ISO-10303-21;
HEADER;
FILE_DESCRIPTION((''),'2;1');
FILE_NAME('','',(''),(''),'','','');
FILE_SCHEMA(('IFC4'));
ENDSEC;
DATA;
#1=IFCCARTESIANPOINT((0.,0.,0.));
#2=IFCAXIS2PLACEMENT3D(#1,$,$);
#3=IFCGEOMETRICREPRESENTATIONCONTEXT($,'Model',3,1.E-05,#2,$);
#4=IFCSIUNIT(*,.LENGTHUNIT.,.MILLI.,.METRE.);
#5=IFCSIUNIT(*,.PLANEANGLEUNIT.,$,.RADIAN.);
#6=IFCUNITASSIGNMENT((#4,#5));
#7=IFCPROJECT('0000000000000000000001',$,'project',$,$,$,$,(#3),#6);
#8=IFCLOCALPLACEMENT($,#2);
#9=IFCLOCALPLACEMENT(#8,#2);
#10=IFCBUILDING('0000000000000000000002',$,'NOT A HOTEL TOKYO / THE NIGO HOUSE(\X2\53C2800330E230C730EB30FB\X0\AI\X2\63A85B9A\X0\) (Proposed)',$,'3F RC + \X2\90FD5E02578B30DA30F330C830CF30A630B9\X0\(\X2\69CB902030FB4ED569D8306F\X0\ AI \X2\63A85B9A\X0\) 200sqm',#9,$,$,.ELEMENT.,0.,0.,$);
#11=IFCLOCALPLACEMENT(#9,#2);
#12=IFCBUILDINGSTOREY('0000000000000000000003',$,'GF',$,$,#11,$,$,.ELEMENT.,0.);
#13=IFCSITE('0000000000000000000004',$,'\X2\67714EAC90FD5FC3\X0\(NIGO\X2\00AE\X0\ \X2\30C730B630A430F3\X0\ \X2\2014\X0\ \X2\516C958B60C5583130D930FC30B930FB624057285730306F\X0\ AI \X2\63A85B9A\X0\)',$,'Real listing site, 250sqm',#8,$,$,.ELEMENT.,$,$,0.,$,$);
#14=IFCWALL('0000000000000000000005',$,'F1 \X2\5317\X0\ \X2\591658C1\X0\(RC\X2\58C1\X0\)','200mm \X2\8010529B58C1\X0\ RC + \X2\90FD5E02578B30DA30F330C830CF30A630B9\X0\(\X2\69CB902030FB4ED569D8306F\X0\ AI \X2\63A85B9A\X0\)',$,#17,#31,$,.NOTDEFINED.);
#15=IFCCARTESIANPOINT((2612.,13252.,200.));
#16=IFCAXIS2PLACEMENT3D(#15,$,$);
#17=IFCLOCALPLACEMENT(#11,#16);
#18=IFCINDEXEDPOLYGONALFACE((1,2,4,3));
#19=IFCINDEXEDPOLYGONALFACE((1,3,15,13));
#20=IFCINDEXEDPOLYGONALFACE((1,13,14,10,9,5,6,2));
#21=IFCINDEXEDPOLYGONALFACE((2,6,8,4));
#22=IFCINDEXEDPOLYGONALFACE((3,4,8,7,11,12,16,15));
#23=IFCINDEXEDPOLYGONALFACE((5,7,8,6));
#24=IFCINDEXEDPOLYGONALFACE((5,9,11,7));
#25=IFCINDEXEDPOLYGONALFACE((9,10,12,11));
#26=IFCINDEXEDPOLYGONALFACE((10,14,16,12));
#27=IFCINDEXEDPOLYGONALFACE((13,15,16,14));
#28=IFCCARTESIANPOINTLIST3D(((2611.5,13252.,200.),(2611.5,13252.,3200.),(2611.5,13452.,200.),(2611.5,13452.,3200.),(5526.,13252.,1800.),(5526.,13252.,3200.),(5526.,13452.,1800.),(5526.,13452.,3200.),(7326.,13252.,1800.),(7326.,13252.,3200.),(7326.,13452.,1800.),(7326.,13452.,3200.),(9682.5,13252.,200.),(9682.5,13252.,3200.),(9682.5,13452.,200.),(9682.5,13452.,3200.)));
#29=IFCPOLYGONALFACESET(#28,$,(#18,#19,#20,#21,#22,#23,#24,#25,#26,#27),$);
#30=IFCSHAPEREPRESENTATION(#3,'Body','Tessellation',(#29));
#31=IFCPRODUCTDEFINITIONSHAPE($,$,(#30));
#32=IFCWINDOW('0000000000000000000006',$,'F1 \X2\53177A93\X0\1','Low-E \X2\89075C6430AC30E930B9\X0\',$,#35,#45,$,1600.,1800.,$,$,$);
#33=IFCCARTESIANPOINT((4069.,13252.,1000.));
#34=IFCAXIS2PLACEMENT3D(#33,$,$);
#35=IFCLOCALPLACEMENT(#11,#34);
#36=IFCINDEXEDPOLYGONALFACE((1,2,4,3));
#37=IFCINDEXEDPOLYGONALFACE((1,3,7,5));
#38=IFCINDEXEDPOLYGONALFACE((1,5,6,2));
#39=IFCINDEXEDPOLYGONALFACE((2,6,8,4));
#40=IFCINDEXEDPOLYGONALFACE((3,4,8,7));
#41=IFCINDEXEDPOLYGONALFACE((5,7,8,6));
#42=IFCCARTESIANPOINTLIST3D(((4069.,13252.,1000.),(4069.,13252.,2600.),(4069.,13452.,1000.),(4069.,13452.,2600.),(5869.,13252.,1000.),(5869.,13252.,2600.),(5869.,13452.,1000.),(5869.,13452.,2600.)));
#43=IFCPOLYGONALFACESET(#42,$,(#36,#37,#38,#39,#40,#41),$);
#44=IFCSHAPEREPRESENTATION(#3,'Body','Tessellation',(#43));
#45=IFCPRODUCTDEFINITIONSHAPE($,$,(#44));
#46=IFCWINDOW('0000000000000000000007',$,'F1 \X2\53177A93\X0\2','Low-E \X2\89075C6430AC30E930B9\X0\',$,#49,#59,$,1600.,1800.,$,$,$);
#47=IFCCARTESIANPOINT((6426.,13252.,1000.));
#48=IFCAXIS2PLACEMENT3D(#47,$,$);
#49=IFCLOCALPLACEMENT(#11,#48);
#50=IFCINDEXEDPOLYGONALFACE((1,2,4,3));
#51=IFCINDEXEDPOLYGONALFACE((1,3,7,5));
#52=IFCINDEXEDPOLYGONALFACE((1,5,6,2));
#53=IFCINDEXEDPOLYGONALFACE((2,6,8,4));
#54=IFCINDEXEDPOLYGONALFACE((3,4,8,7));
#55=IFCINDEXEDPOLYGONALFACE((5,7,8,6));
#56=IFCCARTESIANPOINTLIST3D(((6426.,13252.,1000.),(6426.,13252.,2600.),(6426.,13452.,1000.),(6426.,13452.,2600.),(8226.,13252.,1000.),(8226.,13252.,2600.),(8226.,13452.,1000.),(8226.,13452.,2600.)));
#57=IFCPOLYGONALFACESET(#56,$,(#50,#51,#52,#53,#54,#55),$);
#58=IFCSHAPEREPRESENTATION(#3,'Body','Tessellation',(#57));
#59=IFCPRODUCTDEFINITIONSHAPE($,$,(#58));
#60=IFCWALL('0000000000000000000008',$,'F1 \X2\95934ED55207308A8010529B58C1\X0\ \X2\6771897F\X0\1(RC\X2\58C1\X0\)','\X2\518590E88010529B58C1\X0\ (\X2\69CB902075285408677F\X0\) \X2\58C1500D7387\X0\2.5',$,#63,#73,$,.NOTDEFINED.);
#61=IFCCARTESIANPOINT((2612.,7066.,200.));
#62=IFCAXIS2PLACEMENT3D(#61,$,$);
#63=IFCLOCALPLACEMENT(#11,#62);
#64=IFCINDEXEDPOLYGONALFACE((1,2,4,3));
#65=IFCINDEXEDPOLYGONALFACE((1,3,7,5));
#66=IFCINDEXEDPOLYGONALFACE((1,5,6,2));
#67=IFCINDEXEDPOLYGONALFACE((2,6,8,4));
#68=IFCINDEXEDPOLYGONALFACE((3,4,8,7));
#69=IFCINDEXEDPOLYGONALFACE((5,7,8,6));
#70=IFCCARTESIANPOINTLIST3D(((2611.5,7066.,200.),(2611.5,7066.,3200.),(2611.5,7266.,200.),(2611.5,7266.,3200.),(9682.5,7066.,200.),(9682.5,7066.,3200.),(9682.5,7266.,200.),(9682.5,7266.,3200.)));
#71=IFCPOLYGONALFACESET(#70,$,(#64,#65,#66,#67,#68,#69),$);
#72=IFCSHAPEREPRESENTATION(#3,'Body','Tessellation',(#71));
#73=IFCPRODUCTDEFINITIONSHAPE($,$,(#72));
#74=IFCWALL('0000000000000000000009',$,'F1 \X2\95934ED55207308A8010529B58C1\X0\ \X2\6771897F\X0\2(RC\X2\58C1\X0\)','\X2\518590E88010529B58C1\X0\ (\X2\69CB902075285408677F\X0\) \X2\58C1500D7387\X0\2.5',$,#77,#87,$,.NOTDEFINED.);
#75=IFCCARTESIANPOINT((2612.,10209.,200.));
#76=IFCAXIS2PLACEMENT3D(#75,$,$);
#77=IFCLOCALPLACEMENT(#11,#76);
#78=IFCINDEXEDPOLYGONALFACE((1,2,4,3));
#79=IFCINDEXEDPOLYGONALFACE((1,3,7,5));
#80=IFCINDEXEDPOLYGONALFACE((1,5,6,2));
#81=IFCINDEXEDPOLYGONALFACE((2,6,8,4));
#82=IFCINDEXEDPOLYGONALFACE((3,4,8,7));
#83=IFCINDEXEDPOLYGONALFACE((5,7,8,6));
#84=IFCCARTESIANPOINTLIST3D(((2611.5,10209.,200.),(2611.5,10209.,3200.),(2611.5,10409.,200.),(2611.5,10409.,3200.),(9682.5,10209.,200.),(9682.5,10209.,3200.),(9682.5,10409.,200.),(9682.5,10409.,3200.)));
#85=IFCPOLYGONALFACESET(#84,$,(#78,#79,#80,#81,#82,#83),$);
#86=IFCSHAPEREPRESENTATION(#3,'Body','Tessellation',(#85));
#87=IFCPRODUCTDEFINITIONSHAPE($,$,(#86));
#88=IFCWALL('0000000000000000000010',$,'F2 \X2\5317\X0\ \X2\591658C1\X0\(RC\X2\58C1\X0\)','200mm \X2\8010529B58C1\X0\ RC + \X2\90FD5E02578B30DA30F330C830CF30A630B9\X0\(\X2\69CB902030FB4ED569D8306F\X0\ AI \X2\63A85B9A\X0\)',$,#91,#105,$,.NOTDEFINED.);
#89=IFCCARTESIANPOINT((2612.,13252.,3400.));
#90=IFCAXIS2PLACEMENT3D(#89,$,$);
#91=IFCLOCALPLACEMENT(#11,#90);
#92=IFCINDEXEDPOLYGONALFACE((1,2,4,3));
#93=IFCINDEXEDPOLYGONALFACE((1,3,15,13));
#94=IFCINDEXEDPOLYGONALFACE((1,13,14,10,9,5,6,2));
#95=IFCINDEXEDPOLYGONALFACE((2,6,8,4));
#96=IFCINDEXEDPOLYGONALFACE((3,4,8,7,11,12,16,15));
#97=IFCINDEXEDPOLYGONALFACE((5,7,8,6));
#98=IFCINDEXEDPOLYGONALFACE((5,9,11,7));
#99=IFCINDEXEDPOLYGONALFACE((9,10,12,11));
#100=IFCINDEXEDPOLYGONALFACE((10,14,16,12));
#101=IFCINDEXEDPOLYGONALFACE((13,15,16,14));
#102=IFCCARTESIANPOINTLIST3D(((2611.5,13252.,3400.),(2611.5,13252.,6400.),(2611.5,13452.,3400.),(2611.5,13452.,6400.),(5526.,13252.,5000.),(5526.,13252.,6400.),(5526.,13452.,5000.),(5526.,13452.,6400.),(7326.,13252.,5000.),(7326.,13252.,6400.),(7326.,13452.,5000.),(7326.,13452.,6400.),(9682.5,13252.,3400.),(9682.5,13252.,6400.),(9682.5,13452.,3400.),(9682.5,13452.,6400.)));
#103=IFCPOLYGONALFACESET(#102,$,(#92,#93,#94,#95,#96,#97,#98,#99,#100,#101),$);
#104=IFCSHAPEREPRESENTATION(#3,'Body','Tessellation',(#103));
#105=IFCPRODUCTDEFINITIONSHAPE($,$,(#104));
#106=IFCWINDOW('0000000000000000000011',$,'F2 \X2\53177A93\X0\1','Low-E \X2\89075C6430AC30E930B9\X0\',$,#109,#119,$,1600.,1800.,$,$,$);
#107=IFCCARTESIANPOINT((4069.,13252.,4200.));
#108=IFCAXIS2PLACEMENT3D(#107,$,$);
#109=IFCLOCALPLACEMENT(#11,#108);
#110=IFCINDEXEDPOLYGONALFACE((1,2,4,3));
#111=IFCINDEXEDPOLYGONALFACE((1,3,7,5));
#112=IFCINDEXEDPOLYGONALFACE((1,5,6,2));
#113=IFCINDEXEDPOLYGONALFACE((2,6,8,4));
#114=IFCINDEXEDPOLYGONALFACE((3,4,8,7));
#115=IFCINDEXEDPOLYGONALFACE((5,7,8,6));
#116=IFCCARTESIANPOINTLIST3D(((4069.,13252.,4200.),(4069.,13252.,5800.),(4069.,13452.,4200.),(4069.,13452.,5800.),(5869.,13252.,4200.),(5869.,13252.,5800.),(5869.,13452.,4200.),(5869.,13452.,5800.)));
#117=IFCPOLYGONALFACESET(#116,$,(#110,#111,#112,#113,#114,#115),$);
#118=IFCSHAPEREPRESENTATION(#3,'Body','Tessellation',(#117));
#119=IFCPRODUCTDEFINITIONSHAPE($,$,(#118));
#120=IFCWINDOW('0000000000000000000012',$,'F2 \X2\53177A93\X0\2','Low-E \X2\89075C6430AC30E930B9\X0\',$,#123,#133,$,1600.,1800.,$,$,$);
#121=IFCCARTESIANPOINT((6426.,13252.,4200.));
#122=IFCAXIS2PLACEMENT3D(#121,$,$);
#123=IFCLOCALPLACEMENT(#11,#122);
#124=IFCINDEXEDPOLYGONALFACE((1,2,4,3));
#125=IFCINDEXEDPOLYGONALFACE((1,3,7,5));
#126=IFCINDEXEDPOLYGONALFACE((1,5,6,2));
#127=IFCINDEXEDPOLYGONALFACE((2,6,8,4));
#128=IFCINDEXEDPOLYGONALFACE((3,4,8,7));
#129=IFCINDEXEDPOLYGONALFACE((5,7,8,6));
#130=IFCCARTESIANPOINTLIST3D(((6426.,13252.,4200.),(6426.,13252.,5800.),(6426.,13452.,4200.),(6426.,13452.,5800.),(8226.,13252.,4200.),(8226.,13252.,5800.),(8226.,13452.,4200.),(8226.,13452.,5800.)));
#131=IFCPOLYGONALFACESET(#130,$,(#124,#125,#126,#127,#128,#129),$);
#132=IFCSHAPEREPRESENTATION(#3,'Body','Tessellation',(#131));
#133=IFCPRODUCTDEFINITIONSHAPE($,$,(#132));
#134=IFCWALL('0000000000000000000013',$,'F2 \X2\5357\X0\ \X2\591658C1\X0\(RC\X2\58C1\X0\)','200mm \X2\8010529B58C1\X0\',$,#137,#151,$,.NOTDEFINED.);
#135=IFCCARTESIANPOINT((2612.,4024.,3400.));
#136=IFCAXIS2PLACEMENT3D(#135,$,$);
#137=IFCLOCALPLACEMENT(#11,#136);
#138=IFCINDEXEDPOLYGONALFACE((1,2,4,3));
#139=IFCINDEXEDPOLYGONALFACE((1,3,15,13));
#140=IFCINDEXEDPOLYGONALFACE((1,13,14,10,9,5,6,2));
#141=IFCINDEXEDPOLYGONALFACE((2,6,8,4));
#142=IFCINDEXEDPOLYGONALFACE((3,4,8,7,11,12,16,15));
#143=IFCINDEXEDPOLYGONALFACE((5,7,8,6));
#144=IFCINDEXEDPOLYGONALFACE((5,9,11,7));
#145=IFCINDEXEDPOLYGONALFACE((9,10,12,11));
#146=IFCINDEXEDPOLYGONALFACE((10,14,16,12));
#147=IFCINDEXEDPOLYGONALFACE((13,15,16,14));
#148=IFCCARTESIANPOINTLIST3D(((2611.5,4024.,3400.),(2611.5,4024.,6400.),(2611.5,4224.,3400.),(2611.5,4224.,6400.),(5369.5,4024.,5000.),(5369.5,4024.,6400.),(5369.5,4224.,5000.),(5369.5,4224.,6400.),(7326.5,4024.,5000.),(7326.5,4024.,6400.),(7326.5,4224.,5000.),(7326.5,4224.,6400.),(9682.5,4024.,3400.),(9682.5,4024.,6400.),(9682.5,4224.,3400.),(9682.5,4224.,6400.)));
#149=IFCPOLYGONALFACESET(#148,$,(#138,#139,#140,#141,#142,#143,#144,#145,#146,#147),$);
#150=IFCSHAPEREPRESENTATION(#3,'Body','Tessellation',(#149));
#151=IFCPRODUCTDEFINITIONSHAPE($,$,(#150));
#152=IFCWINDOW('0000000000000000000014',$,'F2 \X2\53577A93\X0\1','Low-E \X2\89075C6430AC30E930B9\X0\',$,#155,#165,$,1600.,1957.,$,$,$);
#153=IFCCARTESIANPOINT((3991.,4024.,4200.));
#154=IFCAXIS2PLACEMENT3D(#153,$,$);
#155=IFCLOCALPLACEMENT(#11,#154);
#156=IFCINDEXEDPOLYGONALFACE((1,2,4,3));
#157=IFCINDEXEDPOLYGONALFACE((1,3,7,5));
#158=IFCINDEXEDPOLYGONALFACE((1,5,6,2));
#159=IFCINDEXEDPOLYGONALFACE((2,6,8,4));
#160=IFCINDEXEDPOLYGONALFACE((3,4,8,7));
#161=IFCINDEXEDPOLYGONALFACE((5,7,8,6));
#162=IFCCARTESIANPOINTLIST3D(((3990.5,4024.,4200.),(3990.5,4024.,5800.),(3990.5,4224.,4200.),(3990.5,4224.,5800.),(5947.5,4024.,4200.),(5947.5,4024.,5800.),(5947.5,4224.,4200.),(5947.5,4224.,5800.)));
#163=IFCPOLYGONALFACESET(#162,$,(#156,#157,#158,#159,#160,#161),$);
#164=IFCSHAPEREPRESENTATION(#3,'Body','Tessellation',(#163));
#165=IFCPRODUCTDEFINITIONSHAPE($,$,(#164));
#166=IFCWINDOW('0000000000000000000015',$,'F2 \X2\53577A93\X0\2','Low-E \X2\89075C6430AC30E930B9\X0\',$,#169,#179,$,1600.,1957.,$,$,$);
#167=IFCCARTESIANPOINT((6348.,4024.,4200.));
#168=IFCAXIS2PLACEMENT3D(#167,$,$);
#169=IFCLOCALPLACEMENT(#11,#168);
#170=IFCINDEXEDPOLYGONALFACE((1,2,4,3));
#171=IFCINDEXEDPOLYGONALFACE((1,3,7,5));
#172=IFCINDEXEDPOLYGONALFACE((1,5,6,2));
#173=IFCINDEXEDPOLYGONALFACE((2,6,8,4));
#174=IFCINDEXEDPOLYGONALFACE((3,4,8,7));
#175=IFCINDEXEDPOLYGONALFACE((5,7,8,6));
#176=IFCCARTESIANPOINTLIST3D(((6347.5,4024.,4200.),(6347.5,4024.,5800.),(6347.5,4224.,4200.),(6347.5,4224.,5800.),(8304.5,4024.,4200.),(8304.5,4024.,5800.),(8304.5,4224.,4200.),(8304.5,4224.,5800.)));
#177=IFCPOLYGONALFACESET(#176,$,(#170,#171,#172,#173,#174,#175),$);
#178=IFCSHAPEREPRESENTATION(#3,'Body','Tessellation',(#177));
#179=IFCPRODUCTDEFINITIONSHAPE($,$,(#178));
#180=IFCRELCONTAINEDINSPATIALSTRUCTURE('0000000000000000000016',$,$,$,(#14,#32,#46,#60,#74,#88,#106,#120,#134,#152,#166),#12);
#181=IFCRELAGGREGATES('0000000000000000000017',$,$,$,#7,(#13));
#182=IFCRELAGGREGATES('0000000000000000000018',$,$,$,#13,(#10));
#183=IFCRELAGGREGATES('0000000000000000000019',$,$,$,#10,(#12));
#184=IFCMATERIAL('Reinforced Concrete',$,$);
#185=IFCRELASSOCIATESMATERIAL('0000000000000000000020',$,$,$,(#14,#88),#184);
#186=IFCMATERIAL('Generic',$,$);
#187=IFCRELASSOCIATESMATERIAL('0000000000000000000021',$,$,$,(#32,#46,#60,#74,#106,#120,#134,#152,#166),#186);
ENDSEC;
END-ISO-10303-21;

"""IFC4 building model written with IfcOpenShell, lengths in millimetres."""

from ifc_helpers import new_model, si_unit, frame, frame_2d, origin, place, context, project, spatial, rectangle, extrude, material, element, fill, save


model = new_model("IFC4")

# Units and contexts
model_context = context("Model", 3, precision=1e-05, world=origin())
ifc_project = project(units=[si_unit("LENGTHUNIT", "METRE", prefix="MILLI"), si_unit("PLANEANGLEUNIT", "RADIAN")], contexts=[model_context])

# Site, building, storey
site_placement = place(None, origin())
site = spatial("IfcSite", under=ifc_project, at=site_placement, Name="東京都心(NIGO® デザイン — 公開情報ベース・所在地は AI 推定)", ObjectType="Real listing site, 250sqm", CompositionType="ELEMENT", RefElevation=0.0)
building_placement = place(site_placement, origin())
building = spatial("IfcBuilding", under=site, at=building_placement, Name="NOT A HOTEL TOKYO / THE NIGO HOUSE(参考モデル・AI推定) (Proposed)", ObjectType="3F RC + 都市型ペントハウス(構造・仕様は AI 推定) 200sqm", CompositionType="ELEMENT", ElevationOfRefHeight=0.0, ElevationOfTerrain=0.0)
storey_placement = place(building_placement, origin())
storey = spatial("IfcBuildingStorey", under=building, at=storey_placement, Name="GF", CompositionType="ELEMENT", Elevation=0.0)

# Wall, openings, windows
ifc_material_1 = material(Name="Reinforced Concrete")
wall_1_placement = place(storey_placement, frame((2612.0, 13252.0, 200.0)))
wall_1 = element("IfcWall", 1, at=wall_1_placement, inside=storey, material=ifc_material_1, Name="F1 北 外壁(RC壁)", Description="200mm 耐力壁 RC + 都市型ペントハウス(構造・仕様は AI 推定)", PredefinedType="NOTDEFINED", context=model_context, shape_type="SweptSolid", body=[
    extrude(rectangle(XDim=7071.0, YDim=200.0, at=frame_2d((3535.0, 100.0))), frame((2612.0, 13252.0, 200.0)), (0.0, 0.0, 1.0), 3000.0),
])
opening_1_placement = place(storey_placement, frame((4069.0, 13252.0, 1000.0)))
opening_1 = element("IfcOpeningElement", 2, at=opening_1_placement, cuts=wall_1, PredefinedType="NOTDEFINED", context=model_context, shape_type="SweptSolid", body=[
    extrude(rectangle(XDim=1800.0, YDim=200.0, at=frame_2d((900.0, 100.0))), frame((4069.0, 13252.0, 1000.0)), (0.0, 0.0, 1.0), 1600.0),
])
opening_2_placement = place(storey_placement, frame((6426.0, 13252.0, 1000.0)))
opening_2 = element("IfcOpeningElement", 3, at=opening_2_placement, cuts=wall_1, PredefinedType="NOTDEFINED", context=model_context, shape_type="SweptSolid", body=[
    extrude(rectangle(XDim=1800.0, YDim=200.0, at=frame_2d((900.0, 100.0))), frame((6426.0, 13252.0, 1000.0)), (0.0, 0.0, 1.0), 1600.0),
])
ifc_material_2 = material(Name="Generic")
window_1_placement = place(storey_placement, frame((4069.0, 13252.0, 1000.0)))
window_1 = element("IfcWindow", 4, at=window_1_placement, inside=storey, material=ifc_material_2, Name="F1 北窓1", Description="Low-E 複層ガラス", OverallHeight=1600.0, OverallWidth=1800.0, context=model_context, shape_type="SweptSolid", body=[
    extrude(rectangle(XDim=1800.0, YDim=200.0, at=frame_2d((900.0, 100.0))), frame((4069.0, 13252.0, 1000.0)), (0.0, 0.0, 1.0), 1600.0),
])
fill(opening_1, window_1)
window_2_placement = place(storey_placement, frame((6426.0, 13252.0, 1000.0)))
window_2 = element("IfcWindow", 5, at=window_2_placement, inside=storey, material=ifc_material_2, Name="F1 北窓2", Description="Low-E 複層ガラス", OverallHeight=1600.0, OverallWidth=1800.0, context=model_context, shape_type="SweptSolid", body=[
    extrude(rectangle(XDim=1800.0, YDim=200.0, at=frame_2d((900.0, 100.0))), frame((6426.0, 13252.0, 1000.0)), (0.0, 0.0, 1.0), 1600.0),
])
fill(opening_2, window_2)

# Walls
wall_2_placement = place(storey_placement, frame((2612.0, 7066.0, 200.0)))
element("IfcWall", 6, at=wall_2_placement, inside=storey, material=ifc_material_2, Name="F1 間仕切り耐力壁 東西1(RC壁)", Description="内部耐力壁 (構造用合板) 壁倍率2.5", PredefinedType="NOTDEFINED", context=model_context, shape_type="SweptSolid", body=[
    extrude(rectangle(XDim=7071.0, YDim=200.0, at=frame_2d((3535.0, 100.0))), frame((2612.0, 7066.0, 200.0)), (0.0, 0.0, 1.0), 3000.0),
])
wall_3_placement = place(storey_placement, frame((2612.0, 10209.0, 200.0)))
element("IfcWall", 7, at=wall_3_placement, inside=storey, material=ifc_material_2, Name="F1 間仕切り耐力壁 東西2(RC壁)", Description="内部耐力壁 (構造用合板) 壁倍率2.5", PredefinedType="NOTDEFINED", context=model_context, shape_type="SweptSolid", body=[
    extrude(rectangle(XDim=7071.0, YDim=200.0, at=frame_2d((3535.0, 100.0))), frame((2612.0, 10209.0, 200.0)), (0.0, 0.0, 1.0), 3000.0),
])

# Walls, openings, windows
wall_4_placement = place(storey_placement, frame((2612.0, 13252.0, 3400.0)))
wall_4 = element("IfcWall", 8, at=wall_4_placement, inside=storey, material=ifc_material_1, Name="F2 北 外壁(RC壁)", Description="200mm 耐力壁 RC + 都市型ペントハウス(構造・仕様は AI 推定)", PredefinedType="NOTDEFINED", context=model_context, shape_type="SweptSolid", body=[
    extrude(rectangle(XDim=7071.0, YDim=200.0, at=frame_2d((3535.0, 100.0))), frame((2612.0, 13252.0, 3400.0)), (0.0, 0.0, 1.0), 3000.0),
])
opening_3_placement = place(storey_placement, frame((4069.0, 13252.0, 4200.0)))
opening_3 = element("IfcOpeningElement", 9, at=opening_3_placement, cuts=wall_4, PredefinedType="NOTDEFINED", context=model_context, shape_type="SweptSolid", body=[
    extrude(rectangle(XDim=1800.0, YDim=200.0, at=frame_2d((900.0, 100.0))), frame((4069.0, 13252.0, 4200.0)), (0.0, 0.0, 1.0), 1600.0),
])
opening_4_placement = place(storey_placement, frame((6426.0, 13252.0, 4200.0)))
opening_4 = element("IfcOpeningElement", 10, at=opening_4_placement, cuts=wall_4, PredefinedType="NOTDEFINED", context=model_context, shape_type="SweptSolid", body=[
    extrude(rectangle(XDim=1800.0, YDim=200.0, at=frame_2d((900.0, 100.0))), frame((6426.0, 13252.0, 4200.0)), (0.0, 0.0, 1.0), 1600.0),
])
window_3_placement = place(storey_placement, frame((4069.0, 13252.0, 4200.0)))
window_3 = element("IfcWindow", 11, at=window_3_placement, inside=storey, material=ifc_material_2, Name="F2 北窓1", Description="Low-E 複層ガラス", OverallHeight=1600.0, OverallWidth=1800.0, context=model_context, shape_type="SweptSolid", body=[
    extrude(rectangle(XDim=1800.0, YDim=200.0, at=frame_2d((900.0, 100.0))), frame((4069.0, 13252.0, 4200.0)), (0.0, 0.0, 1.0), 1600.0),
])
fill(opening_3, window_3)
window_4_placement = place(storey_placement, frame((6426.0, 13252.0, 4200.0)))
window_4 = element("IfcWindow", 12, at=window_4_placement, inside=storey, material=ifc_material_2, Name="F2 北窓2", Description="Low-E 複層ガラス", OverallHeight=1600.0, OverallWidth=1800.0, context=model_context, shape_type="SweptSolid", body=[
    extrude(rectangle(XDim=1800.0, YDim=200.0, at=frame_2d((900.0, 100.0))), frame((6426.0, 13252.0, 4200.0)), (0.0, 0.0, 1.0), 1600.0),
])
fill(opening_4, window_4)
wall_5_placement = place(storey_placement, frame((2612.0, 4024.0, 3400.0)))
wall_5 = element("IfcWall", 13, at=wall_5_placement, inside=storey, material=ifc_material_2, Name="F2 南 外壁(RC壁)", Description="200mm 耐力壁", PredefinedType="NOTDEFINED", context=model_context, shape_type="SweptSolid", body=[
    extrude(rectangle(XDim=7071.0, YDim=200.0, at=frame_2d((3535.0, 100.0))), frame((2612.0, 4024.0, 3400.0)), (0.0, 0.0, 1.0), 3000.0),
])
opening_5_placement = place(storey_placement, frame((3991.0, 4024.0, 4200.0)))
opening_5 = element("IfcOpeningElement", 14, at=opening_5_placement, cuts=wall_5, PredefinedType="NOTDEFINED", context=model_context, shape_type="SweptSolid", body=[
    extrude(rectangle(XDim=1957.0, YDim=200.0, at=frame_2d((978.0, 100.0))), frame((3991.0, 4024.0, 4200.0)), (0.0, 0.0, 1.0), 1600.0),
])
opening_6_placement = place(storey_placement, frame((6348.0, 4024.0, 4200.0)))
opening_6 = element("IfcOpeningElement", 15, at=opening_6_placement, cuts=wall_5, PredefinedType="NOTDEFINED", context=model_context, shape_type="SweptSolid", body=[
    extrude(rectangle(XDim=1957.0, YDim=200.0, at=frame_2d((978.0, 100.0))), frame((6348.0, 4024.0, 4200.0)), (0.0, 0.0, 1.0), 1600.0),
])
window_5_placement = place(storey_placement, frame((3991.0, 4024.0, 4200.0)))
window_5 = element("IfcWindow", 16, at=window_5_placement, inside=storey, material=ifc_material_2, Name="F2 南窓1", Description="Low-E 複層ガラス", OverallHeight=1600.0, OverallWidth=1957.0, context=model_context, shape_type="SweptSolid", body=[
    extrude(rectangle(XDim=1957.0, YDim=200.0, at=frame_2d((978.0, 100.0))), frame((3991.0, 4024.0, 4200.0)), (0.0, 0.0, 1.0), 1600.0),
])
fill(opening_5, window_5)
window_6_placement = place(storey_placement, frame((6348.0, 4024.0, 4200.0)))
window_6 = element("IfcWindow", 17, at=window_6_placement, inside=storey, material=ifc_material_2, Name="F2 南窓2", Description="Low-E 複層ガラス", OverallHeight=1600.0, OverallWidth=1957.0, context=model_context, shape_type="SweptSolid", body=[
    extrude(rectangle(XDim=1957.0, YDim=200.0, at=frame_2d((978.0, 100.0))), frame((6348.0, 4024.0, 4200.0)), (0.0, 0.0, 1.0), 1600.0),
])
fill(opening_6, window_6)

save(model, "model.ifc")
